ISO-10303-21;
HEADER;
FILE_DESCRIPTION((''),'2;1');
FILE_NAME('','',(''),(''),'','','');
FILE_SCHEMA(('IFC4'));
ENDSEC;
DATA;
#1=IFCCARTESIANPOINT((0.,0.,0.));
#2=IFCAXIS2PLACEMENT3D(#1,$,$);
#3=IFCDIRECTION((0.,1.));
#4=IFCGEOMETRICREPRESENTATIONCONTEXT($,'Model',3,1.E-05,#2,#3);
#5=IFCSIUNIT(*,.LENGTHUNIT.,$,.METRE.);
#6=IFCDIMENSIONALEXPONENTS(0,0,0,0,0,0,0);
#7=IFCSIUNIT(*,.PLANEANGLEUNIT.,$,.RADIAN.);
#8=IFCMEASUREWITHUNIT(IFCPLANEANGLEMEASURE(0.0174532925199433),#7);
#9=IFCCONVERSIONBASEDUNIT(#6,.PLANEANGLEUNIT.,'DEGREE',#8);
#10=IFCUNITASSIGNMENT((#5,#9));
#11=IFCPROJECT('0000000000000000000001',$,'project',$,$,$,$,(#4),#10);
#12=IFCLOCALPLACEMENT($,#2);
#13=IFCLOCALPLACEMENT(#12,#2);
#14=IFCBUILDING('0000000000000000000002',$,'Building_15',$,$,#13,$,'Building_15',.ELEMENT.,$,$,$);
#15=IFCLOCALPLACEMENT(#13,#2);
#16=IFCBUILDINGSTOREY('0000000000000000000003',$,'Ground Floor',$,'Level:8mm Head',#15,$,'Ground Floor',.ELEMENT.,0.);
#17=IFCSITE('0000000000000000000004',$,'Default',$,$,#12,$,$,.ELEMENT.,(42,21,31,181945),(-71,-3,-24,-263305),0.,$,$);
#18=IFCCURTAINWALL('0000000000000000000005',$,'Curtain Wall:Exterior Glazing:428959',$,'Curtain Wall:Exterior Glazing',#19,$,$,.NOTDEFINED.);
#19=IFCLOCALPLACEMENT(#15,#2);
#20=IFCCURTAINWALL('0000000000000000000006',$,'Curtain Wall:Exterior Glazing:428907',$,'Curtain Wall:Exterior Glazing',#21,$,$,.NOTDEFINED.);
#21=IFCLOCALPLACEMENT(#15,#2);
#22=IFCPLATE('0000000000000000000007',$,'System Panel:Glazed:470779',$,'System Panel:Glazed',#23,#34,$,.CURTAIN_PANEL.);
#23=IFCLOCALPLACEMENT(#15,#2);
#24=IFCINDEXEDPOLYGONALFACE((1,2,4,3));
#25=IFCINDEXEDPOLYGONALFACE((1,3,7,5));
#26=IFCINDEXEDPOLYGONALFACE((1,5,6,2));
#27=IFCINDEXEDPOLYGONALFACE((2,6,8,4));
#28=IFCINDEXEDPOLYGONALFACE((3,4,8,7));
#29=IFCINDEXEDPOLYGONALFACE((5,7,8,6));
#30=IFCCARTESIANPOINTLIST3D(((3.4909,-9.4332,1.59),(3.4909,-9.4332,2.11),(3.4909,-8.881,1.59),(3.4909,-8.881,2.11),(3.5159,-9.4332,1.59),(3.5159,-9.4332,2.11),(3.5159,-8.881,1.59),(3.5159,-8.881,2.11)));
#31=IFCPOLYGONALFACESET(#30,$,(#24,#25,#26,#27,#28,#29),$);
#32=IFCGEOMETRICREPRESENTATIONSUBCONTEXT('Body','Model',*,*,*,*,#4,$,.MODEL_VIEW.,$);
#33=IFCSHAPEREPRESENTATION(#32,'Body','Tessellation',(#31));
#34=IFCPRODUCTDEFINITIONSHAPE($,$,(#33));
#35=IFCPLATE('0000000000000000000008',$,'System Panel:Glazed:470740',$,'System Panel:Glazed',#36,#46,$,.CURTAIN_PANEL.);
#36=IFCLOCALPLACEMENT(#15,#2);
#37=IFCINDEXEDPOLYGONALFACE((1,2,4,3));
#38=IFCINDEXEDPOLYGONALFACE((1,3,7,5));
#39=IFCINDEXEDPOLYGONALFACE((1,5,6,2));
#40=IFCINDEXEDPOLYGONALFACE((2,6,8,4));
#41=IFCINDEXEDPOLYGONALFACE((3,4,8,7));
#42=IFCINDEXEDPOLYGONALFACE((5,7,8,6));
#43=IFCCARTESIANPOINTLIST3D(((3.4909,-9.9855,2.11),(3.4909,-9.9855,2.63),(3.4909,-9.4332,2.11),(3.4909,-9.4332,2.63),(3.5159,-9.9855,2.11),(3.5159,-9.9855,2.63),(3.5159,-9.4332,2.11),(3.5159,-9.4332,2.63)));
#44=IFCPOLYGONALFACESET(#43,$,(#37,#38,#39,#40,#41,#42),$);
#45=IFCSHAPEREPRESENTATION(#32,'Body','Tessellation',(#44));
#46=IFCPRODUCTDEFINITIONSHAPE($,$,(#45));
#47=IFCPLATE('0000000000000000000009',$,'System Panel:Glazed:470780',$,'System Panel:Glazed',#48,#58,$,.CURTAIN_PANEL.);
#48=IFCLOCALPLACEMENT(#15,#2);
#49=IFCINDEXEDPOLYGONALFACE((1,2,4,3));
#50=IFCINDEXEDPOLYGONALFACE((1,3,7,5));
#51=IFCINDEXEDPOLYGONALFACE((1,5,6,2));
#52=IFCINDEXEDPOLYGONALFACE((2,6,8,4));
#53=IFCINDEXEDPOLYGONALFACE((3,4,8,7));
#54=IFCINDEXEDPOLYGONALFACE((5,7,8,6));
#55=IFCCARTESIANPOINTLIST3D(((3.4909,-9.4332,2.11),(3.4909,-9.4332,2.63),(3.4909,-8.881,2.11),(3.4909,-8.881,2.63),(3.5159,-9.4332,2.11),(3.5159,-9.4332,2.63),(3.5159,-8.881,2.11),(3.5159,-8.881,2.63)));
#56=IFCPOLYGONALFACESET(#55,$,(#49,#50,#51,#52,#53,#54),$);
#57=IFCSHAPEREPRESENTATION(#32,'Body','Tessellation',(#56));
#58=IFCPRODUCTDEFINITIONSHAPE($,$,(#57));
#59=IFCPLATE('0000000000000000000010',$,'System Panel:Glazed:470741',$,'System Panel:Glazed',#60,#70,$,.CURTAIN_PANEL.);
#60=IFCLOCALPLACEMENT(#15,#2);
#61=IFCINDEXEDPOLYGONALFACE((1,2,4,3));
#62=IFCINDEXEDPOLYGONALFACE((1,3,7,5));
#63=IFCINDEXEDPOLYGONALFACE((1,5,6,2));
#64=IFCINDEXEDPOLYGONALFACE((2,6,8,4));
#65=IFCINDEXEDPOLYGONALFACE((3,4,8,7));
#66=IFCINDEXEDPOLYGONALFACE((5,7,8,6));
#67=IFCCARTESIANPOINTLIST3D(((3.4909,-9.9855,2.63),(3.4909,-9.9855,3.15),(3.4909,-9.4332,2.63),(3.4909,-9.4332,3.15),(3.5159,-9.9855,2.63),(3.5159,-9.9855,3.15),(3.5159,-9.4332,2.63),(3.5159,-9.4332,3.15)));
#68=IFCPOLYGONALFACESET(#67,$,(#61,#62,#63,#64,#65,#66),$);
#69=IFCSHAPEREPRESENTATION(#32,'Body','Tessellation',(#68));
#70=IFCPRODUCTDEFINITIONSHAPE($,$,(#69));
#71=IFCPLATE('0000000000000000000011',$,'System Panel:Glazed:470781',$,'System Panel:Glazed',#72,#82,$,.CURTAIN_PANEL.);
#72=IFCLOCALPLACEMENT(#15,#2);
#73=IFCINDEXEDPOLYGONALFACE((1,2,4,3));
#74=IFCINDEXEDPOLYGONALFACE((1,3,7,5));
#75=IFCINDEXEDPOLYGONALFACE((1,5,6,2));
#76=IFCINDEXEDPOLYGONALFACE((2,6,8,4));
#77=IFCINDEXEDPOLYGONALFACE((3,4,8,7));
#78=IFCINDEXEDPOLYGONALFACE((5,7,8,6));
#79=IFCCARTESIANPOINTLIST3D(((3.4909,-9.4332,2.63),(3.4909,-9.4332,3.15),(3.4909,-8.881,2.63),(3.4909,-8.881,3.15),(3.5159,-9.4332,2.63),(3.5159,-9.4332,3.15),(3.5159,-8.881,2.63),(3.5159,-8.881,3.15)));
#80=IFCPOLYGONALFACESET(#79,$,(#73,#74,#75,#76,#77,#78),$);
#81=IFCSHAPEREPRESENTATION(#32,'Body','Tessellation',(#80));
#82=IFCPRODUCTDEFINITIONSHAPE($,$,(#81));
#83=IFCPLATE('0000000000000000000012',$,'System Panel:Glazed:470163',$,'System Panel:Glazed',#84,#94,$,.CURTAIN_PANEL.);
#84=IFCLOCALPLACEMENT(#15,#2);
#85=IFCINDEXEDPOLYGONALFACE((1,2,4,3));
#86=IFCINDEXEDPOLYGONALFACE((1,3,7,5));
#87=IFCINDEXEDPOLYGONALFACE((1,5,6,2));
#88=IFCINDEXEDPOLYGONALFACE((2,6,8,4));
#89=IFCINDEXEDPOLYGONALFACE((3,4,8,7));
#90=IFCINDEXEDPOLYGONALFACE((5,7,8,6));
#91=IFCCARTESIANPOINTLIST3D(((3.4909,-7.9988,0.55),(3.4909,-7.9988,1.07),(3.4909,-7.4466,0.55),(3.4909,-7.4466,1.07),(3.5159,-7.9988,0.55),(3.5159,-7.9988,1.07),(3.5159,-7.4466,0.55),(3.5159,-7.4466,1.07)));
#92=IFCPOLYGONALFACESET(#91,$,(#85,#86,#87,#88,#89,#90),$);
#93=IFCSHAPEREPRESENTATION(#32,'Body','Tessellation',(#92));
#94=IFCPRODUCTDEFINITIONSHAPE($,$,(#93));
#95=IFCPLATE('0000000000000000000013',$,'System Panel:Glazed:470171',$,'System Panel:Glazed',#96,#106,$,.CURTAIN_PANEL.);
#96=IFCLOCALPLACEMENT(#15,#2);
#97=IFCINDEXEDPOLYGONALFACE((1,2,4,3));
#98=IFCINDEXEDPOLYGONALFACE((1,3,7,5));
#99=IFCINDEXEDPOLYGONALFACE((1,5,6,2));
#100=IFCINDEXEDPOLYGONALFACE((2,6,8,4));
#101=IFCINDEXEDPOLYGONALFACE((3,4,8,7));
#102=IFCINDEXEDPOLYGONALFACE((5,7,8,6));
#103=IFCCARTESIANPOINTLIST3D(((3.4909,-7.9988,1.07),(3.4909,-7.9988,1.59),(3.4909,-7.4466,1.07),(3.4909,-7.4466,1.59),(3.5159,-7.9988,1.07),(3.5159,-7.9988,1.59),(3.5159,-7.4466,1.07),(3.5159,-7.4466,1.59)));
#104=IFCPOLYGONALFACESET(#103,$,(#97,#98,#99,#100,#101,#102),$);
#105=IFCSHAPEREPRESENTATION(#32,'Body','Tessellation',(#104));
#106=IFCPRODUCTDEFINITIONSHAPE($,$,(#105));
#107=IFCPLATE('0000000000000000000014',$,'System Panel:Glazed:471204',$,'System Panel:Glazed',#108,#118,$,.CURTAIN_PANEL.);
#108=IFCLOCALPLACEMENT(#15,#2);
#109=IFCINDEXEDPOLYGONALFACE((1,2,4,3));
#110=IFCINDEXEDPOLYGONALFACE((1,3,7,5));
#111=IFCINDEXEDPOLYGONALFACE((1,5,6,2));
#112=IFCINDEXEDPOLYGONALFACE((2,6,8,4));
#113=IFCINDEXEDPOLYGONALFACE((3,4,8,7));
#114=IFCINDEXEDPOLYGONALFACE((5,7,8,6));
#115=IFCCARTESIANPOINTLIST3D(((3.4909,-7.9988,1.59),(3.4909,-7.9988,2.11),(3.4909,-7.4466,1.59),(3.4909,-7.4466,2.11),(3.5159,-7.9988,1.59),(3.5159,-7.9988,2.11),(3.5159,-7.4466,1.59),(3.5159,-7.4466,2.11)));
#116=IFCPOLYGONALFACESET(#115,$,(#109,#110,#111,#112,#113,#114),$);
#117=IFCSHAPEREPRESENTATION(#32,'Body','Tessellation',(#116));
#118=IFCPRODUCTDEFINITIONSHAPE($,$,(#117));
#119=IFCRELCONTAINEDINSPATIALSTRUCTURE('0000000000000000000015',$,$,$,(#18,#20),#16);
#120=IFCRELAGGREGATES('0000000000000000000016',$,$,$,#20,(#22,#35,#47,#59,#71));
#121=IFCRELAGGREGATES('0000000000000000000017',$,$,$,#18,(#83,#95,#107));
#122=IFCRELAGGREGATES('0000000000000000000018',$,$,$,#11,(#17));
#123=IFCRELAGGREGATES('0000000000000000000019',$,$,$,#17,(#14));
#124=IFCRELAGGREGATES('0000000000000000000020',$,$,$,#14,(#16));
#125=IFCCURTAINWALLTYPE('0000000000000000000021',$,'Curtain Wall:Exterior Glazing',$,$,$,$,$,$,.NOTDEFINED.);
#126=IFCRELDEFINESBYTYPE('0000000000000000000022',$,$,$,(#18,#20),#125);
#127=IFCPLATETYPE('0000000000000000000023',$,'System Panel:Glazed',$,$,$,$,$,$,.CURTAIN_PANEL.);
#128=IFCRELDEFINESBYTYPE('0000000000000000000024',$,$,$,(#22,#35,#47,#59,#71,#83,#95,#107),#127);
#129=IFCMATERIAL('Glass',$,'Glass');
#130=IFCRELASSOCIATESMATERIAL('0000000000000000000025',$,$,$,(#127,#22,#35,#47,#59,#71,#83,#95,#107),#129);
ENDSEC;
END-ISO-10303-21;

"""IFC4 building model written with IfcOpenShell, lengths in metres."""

from ifc_helpers import new_model, entity, si_unit, converted_unit, direction, frame, origin, place, context, subcontext, project, spatial, indexed_curve, outline, extrude, source, transform, mapped, material, type_object, type_shapes, element, aggregate, save


model = new_model("IFC4")

# Units and contexts
model_context = context("Model", 3, precision=1e-05, world=origin(), true_north=direction((0.0, 1.0)))
body_context = subcontext(model_context, "Body", "Model", "MODEL_VIEW")
ifc_project = project(units=[si_unit("LENGTHUNIT", "METRE"), converted_unit("PLANEANGLEUNIT", "DEGREE", entity("IfcPlaneAngleMeasure", 0.0174532925199433), si_unit("PLANEANGLEUNIT", "RADIAN"), dimensions=[0, 0, 0, 0, 0, 0, 0])], contexts=[model_context])

# Site, building, storey
site_placement = place(None, origin())
site = spatial("IfcSite", under=ifc_project, at=site_placement, Name="Default", CompositionType="ELEMENT", RefLatitude=(42, 21, 31, 181945), RefLongitude=(-71, -3, -24, -263305), RefElevation=0.0)
building_placement = place(site_placement, origin())
building = spatial("IfcBuilding", under=site, at=building_placement, Name="Building_15", LongName="Building_15", CompositionType="ELEMENT")
storey_placement = place(building_placement, origin())
storey = spatial("IfcBuildingStorey", under=building, at=storey_placement, Name="Ground Floor", ObjectType="Level:8mm Head", LongName="Ground Floor", CompositionType="ELEMENT", Elevation=0.0)

# Curtain wall
curtain_wall_type = type_object("IfcCurtainWallType", Name="Curtain Wall:Exterior Glazing", PredefinedType="NOTDEFINED")
curtain_wall_1_placement = place(storey_placement, origin())
curtain_wall_1 = element("IfcCurtainWall", 1, at=curtain_wall_1_placement, inside=storey, type_object=curtain_wall_type, Name="Curtain Wall:Exterior Glazing:428959", ObjectType="Curtain Wall:Exterior Glazing", PredefinedType="NOTDEFINED")

# Curtain wall
curtain_wall_2_placement = place(storey_placement, origin())
curtain_wall_2 = element("IfcCurtainWall", 2, at=curtain_wall_2_placement, inside=storey, type_object=curtain_wall_type, Name="Curtain Wall:Exterior Glazing:428907", ObjectType="Curtain Wall:Exterior Glazing", PredefinedType="NOTDEFINED")

# Plates
ifc_material_1 = material(Name="Glass", Category="Glass")
plate_type_1 = type_object("IfcPlateType", Name="System Panel:Glazed", PredefinedType="CURTAIN_PANEL", material=ifc_material_1)
shared_shape_1 = source(origin(), body_context, "Body", "SweptSolid", [
    extrude(outline(indexed_curve([(-0.0125, -0.2761), (0.0125, -0.2761), (0.0125, 0.2761), (-0.0125, 0.2761), (-0.0125, -0.2761)], self_intersect=False)), frame((0.0, 0.037, 0.0), z_axis=(0.0, 0.0, 1.0), x_axis=(0.0, 1.0, 0.0)), (0.0, 0.0, 1.0), 0.52),
])
type_shapes(plate_type_1, [shared_shape_1])
plate_1_placement = place(curtain_wall_2_placement, frame((3.5404, -9.1571, 1.59), z_axis=(0.0, 0.0, 1.0), x_axis=(0.0, 1.0, 0.0)))
plate_1 = element("IfcPlate", 3, at=plate_1_placement, type_object=plate_type_1, material=ifc_material_1, Name="System Panel:Glazed:470779", ObjectType="System Panel:Glazed", PredefinedType="CURTAIN_PANEL", context=body_context, shape_type="MappedRepresentation", body=[
    mapped(shared_shape_1, transform((0.0, 0.0, 0.0), scale=1.0)),
])
plate_2_placement = place(curtain_wall_2_placement, frame((3.5404, -9.7093, 2.11), z_axis=(0.0, 0.0, 1.0), x_axis=(0.0, 1.0, 0.0)))
plate_2 = element("IfcPlate", 4, at=plate_2_placement, type_object=plate_type_1, material=ifc_material_1, Name="System Panel:Glazed:470740", ObjectType="System Panel:Glazed", PredefinedType="CURTAIN_PANEL", context=body_context, shape_type="MappedRepresentation", body=[
    mapped(shared_shape_1, transform((0.0, 0.0, 0.0), scale=1.0)),
])
plate_3_placement = place(curtain_wall_2_placement, frame((3.5404, -9.1571, 2.11), z_axis=(0.0, 0.0, 1.0), x_axis=(0.0, 1.0, 0.0)))
plate_3 = element("IfcPlate", 5, at=plate_3_placement, type_object=plate_type_1, material=ifc_material_1, Name="System Panel:Glazed:470780", ObjectType="System Panel:Glazed", PredefinedType="CURTAIN_PANEL", context=body_context, shape_type="MappedRepresentation", body=[
    mapped(shared_shape_1, transform((0.0, 0.0, 0.0), scale=1.0)),
])
plate_4_placement = place(curtain_wall_2_placement, frame((3.5404, -9.7093, 2.63), z_axis=(0.0, 0.0, 1.0), x_axis=(0.0, 1.0, 0.0)))
plate_4 = element("IfcPlate", 6, at=plate_4_placement, type_object=plate_type_1, material=ifc_material_1, Name="System Panel:Glazed:470741", ObjectType="System Panel:Glazed", PredefinedType="CURTAIN_PANEL", context=body_context, shape_type="MappedRepresentation", body=[
    mapped(shared_shape_1, transform((0.0, 0.0, 0.0), scale=1.0)),
])
plate_5_placement = place(curtain_wall_2_placement, frame((3.5404, -9.1571, 2.63), z_axis=(0.0, 0.0, 1.0), x_axis=(0.0, 1.0, 0.0)))
plate_5 = element("IfcPlate", 7, at=plate_5_placement, type_object=plate_type_1, material=ifc_material_1, Name="System Panel:Glazed:470781", ObjectType="System Panel:Glazed", PredefinedType="CURTAIN_PANEL", context=body_context, shape_type="MappedRepresentation", body=[
    mapped(shared_shape_1, transform((0.0, 0.0, 0.0), scale=1.0)),
])
aggregate(curtain_wall_2, [plate_1, plate_2, plate_3, plate_4, plate_5])
plate_6_placement = place(curtain_wall_1_placement, frame((3.5404, -7.7227, 0.55), z_axis=(0.0, 0.0, 1.0), x_axis=(0.0, 1.0, 0.0)))
plate_6 = element("IfcPlate", 8, at=plate_6_placement, type_object=plate_type_1, material=ifc_material_1, Name="System Panel:Glazed:470163", ObjectType="System Panel:Glazed", PredefinedType="CURTAIN_PANEL", context=body_context, shape_type="MappedRepresentation", body=[
    mapped(shared_shape_1, transform((0.0, 0.0, 0.0), scale=1.0)),
])
plate_7_placement = place(curtain_wall_1_placement, frame((3.5404, -7.7227, 1.07), z_axis=(0.0, 0.0, 1.0), x_axis=(0.0, 1.0, 0.0)))
plate_7 = element("IfcPlate", 9, at=plate_7_placement, type_object=plate_type_1, material=ifc_material_1, Name="System Panel:Glazed:470171", ObjectType="System Panel:Glazed", PredefinedType="CURTAIN_PANEL", context=body_context, shape_type="MappedRepresentation", body=[
    mapped(shared_shape_1, transform((0.0, 0.0, 0.0), scale=1.0)),
])
plate_8_placement = place(curtain_wall_1_placement, frame((3.5404, -7.7227, 1.59), z_axis=(0.0, 0.0, 1.0), x_axis=(0.0, 1.0, 0.0)))
plate_8 = element("IfcPlate", 10, at=plate_8_placement, type_object=plate_type_1, material=ifc_material_1, Name="System Panel:Glazed:471204", ObjectType="System Panel:Glazed", PredefinedType="CURTAIN_PANEL", context=body_context, shape_type="MappedRepresentation", body=[
    mapped(shared_shape_1, transform((0.0, 0.0, 0.0), scale=1.0)),
])
aggregate(curtain_wall_1, [plate_6, plate_7, plate_8])

save(model, "model.ifc")
